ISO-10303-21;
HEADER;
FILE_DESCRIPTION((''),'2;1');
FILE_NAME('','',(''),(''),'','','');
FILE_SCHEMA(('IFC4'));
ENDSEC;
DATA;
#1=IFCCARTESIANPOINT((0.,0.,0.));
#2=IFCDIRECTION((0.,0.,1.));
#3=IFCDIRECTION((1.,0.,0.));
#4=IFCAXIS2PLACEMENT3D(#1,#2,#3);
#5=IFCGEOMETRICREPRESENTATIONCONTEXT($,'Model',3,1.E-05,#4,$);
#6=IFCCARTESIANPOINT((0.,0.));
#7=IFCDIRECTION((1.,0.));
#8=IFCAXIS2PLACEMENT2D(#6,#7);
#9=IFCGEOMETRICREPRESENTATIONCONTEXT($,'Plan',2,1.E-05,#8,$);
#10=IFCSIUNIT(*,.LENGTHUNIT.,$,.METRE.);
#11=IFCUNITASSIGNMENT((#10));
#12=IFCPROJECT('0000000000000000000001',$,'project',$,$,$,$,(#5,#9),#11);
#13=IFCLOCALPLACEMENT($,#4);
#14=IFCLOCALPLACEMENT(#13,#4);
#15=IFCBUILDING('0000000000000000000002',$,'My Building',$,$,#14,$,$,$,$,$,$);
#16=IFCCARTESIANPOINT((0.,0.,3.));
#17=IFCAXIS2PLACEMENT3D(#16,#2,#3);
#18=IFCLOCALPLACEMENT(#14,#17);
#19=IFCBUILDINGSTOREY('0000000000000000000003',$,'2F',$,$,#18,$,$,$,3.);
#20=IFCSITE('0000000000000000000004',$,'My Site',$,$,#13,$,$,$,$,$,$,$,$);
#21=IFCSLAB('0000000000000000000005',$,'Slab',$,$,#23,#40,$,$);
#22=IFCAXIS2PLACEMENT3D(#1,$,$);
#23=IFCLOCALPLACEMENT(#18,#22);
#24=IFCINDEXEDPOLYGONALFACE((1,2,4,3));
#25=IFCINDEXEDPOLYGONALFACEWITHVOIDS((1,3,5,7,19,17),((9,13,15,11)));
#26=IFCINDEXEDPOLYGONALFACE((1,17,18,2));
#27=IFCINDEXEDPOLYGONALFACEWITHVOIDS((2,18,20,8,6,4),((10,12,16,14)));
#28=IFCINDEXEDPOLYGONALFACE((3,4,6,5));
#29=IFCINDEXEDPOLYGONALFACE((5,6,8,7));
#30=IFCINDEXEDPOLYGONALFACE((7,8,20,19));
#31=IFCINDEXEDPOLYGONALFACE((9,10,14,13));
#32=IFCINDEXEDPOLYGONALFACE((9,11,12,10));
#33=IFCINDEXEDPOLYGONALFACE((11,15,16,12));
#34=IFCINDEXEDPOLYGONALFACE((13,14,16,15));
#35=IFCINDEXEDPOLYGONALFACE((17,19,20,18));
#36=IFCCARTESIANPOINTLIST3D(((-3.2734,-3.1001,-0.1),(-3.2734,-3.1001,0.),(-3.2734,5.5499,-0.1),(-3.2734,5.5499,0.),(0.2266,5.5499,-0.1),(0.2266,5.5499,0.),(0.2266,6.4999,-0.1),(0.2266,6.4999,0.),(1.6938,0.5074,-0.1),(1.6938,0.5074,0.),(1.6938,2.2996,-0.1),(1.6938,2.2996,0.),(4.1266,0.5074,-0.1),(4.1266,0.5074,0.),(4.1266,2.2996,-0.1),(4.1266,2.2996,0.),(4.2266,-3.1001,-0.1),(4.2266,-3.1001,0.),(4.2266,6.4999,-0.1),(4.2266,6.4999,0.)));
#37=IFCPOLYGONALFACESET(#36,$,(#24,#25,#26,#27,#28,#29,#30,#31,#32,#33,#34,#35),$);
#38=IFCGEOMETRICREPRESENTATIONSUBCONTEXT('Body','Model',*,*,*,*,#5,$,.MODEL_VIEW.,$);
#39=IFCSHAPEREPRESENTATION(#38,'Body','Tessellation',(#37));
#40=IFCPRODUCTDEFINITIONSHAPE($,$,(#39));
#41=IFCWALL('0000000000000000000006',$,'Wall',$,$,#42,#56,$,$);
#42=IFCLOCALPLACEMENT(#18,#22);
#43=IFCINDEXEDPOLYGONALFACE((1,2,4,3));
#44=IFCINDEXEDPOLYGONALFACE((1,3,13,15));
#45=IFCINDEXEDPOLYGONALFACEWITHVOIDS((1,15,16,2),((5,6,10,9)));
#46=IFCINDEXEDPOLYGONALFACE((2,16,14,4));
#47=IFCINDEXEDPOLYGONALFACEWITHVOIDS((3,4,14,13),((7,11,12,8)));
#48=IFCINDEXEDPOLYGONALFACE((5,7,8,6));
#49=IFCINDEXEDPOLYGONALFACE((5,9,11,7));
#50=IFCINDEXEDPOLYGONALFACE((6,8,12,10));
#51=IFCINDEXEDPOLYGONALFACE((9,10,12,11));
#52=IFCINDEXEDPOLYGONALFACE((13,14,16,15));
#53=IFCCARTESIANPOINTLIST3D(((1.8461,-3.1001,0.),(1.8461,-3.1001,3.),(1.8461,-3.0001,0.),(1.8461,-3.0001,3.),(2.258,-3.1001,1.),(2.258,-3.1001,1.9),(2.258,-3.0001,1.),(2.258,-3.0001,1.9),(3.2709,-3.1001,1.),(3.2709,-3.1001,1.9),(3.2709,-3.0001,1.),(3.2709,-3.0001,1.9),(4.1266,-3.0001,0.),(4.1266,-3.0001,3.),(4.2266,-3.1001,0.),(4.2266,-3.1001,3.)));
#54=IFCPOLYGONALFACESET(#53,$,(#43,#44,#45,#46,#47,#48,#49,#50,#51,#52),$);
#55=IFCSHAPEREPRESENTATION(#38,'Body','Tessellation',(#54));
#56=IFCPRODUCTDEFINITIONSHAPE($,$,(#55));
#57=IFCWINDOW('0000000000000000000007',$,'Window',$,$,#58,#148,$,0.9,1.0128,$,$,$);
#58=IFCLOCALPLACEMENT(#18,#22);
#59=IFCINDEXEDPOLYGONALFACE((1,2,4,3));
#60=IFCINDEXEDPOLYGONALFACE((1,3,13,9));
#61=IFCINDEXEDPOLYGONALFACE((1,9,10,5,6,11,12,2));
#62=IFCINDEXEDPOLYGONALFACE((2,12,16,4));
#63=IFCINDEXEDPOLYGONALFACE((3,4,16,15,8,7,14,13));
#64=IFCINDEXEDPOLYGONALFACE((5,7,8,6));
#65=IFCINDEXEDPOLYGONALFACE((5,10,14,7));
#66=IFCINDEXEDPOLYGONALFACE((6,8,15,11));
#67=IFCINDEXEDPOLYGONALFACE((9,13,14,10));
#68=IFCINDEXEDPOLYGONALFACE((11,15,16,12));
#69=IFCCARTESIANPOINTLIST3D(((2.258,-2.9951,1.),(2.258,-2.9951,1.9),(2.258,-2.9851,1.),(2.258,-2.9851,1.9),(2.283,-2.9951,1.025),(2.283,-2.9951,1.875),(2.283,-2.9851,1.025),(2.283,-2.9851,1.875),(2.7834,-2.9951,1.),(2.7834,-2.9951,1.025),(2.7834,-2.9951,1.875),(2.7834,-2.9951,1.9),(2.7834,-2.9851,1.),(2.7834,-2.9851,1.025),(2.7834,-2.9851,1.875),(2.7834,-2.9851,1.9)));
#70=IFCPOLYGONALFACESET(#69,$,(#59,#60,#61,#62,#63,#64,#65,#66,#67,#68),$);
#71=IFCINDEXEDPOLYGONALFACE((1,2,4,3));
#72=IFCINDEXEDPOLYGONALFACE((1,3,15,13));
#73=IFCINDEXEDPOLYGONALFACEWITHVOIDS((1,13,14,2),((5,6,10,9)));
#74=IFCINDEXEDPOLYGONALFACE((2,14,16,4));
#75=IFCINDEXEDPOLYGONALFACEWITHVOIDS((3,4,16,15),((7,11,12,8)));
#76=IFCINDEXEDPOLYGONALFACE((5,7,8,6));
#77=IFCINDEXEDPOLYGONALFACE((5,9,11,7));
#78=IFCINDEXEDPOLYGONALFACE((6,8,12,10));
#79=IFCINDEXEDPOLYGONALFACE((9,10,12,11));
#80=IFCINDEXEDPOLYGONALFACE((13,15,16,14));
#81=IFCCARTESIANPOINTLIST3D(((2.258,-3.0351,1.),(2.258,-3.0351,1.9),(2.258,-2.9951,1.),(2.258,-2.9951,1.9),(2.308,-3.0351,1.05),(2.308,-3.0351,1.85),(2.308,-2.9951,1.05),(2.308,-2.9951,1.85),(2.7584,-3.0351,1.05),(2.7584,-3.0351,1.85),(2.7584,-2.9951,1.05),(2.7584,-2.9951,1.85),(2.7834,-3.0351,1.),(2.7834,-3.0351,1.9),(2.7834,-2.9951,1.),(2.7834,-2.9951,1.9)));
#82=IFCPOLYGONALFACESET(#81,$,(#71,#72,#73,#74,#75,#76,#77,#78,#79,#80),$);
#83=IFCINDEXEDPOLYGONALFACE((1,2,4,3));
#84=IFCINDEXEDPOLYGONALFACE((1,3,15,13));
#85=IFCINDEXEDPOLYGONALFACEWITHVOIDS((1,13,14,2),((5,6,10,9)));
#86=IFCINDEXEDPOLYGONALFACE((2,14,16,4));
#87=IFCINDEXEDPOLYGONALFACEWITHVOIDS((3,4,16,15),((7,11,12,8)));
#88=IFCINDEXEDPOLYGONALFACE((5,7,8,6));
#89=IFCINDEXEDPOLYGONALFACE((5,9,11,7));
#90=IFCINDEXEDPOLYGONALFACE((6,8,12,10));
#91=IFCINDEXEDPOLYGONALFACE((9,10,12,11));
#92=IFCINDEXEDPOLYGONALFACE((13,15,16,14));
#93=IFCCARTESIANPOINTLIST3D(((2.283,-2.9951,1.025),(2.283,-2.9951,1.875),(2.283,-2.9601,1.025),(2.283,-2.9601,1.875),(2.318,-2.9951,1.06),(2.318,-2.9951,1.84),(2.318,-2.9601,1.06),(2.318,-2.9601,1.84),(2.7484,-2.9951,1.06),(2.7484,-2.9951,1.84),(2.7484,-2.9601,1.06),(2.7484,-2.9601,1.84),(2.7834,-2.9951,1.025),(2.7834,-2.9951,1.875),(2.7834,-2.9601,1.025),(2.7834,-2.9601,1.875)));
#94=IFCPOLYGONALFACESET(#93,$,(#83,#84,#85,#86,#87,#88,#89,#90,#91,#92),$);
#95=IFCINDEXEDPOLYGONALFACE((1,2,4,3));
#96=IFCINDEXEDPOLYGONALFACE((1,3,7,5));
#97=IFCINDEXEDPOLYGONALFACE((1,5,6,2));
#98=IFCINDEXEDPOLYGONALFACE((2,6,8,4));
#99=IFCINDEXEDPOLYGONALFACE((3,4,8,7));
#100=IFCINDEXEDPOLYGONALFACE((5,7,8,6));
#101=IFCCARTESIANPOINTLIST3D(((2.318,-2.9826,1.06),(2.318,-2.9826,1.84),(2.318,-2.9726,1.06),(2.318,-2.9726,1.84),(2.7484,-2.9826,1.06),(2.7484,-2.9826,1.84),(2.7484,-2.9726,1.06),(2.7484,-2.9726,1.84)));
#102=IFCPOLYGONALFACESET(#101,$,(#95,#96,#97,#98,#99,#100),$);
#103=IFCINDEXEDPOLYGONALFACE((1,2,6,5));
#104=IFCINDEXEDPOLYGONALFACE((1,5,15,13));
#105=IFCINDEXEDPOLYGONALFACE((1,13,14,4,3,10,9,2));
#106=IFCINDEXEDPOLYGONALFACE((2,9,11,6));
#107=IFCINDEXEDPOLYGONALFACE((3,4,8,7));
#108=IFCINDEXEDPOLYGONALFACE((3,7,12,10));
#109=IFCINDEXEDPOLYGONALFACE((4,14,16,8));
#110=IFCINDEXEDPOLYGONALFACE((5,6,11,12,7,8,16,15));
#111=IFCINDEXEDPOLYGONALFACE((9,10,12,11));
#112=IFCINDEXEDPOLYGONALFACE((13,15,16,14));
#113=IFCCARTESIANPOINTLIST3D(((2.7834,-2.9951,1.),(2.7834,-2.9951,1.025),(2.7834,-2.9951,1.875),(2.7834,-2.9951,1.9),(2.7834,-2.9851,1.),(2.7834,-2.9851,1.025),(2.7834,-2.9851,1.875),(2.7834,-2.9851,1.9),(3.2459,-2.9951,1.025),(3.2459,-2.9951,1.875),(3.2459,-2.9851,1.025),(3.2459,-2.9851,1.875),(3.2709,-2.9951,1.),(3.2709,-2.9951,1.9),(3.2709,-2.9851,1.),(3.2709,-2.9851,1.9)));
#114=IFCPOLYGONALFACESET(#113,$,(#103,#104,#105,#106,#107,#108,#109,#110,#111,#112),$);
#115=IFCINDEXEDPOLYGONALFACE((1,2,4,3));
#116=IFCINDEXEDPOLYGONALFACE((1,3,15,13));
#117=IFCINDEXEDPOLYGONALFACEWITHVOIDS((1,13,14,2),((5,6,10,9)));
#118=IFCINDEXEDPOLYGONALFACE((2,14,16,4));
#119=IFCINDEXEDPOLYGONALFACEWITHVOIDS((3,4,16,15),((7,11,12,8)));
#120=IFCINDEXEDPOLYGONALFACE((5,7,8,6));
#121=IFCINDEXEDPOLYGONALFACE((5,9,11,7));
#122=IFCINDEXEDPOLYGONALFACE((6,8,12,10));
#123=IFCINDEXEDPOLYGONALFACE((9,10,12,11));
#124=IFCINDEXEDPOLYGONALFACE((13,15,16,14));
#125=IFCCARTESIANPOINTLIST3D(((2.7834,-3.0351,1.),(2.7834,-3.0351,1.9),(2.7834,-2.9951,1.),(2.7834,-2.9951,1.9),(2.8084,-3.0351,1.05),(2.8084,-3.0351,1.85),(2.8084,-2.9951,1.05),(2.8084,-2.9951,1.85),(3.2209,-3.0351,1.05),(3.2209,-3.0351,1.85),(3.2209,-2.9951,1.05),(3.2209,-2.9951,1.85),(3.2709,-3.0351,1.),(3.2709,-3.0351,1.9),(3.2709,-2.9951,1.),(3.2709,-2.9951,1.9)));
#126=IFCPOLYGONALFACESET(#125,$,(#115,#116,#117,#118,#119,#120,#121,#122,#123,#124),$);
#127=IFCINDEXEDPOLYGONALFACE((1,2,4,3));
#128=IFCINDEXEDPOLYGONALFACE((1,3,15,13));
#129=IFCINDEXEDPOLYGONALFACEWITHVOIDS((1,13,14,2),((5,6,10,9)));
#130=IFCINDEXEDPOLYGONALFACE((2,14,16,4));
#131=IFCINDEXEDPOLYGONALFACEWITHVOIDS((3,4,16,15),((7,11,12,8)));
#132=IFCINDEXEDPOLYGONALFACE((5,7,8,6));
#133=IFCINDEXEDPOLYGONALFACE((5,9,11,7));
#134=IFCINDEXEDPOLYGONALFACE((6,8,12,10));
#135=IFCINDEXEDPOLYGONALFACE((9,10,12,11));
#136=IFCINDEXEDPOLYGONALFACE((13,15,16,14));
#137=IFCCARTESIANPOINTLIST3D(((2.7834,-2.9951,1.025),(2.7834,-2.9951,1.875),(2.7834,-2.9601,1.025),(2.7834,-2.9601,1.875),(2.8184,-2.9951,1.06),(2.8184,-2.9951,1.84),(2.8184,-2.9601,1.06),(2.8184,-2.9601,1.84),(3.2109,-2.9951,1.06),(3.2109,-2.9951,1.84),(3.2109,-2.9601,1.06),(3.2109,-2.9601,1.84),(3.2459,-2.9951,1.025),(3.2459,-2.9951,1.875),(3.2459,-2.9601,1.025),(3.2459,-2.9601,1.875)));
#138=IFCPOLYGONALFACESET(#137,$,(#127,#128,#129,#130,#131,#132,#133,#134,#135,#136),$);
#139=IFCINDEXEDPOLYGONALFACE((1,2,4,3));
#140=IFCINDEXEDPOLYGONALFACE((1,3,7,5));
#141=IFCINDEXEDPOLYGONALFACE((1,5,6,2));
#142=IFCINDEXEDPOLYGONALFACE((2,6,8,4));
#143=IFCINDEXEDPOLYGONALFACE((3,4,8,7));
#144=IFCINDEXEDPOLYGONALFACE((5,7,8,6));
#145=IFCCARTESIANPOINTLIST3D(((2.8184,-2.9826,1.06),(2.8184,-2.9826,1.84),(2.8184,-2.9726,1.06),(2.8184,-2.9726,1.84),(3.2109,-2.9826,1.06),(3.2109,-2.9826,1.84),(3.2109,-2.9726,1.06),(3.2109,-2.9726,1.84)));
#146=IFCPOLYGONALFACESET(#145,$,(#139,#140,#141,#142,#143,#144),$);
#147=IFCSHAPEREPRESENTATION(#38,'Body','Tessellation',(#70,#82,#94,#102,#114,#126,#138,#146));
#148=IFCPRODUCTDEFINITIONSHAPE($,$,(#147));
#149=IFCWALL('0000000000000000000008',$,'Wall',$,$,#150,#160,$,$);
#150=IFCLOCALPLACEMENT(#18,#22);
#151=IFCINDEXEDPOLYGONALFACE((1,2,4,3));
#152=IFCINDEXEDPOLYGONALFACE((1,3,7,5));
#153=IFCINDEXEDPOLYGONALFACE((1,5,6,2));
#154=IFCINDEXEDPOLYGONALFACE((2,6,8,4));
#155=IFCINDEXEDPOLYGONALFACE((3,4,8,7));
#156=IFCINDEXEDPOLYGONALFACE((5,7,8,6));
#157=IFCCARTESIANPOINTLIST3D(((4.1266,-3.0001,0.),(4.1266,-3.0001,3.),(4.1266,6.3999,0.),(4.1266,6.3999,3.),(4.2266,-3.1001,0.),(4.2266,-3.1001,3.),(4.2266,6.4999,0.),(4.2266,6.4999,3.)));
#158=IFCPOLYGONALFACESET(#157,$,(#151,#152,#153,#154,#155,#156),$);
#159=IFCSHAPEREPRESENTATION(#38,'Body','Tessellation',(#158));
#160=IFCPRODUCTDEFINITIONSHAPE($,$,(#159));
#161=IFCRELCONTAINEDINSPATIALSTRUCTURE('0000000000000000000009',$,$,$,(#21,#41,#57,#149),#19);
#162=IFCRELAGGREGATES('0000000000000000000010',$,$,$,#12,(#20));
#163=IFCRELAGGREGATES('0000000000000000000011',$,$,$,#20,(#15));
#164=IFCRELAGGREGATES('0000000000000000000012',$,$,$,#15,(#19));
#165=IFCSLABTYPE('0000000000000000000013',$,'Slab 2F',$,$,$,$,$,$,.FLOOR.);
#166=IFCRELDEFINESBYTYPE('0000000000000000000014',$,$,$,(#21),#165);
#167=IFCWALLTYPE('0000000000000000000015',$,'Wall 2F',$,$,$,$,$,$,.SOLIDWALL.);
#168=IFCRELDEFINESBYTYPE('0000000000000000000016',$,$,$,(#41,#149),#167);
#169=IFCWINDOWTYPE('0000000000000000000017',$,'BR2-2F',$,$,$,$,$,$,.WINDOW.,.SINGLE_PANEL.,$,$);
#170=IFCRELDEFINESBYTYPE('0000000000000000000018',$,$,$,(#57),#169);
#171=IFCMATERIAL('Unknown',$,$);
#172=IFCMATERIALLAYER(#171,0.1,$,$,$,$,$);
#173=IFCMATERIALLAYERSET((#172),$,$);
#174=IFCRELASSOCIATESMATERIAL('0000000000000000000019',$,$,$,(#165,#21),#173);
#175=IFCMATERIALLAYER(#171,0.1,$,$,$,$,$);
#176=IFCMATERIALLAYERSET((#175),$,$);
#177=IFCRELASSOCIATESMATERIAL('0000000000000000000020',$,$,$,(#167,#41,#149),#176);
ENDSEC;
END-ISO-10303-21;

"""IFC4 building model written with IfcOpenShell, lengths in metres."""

from ifc_helpers import new_model, entity, si_unit, frame, origin_with_axes, origin_2d_with_axis, place, context, subcontext, project, spatial, polyline, line, indexed_curve, outline, extrude, shape, source, transform, mapped, material, layer, layer_set, layer_usage, type_object, type_shapes, element, fill, save


model = new_model("IFC4")

# Units and contexts
model_context = context("Model", 3, precision=1e-05, world=origin_with_axes())
plan_context = context("Plan", 2, precision=1e-05, world=origin_2d_with_axis())
body_context_1 = subcontext(model_context, "Body", "Model", "MODEL_VIEW")
body_context_2 = subcontext(plan_context, "Body", "Plan", "PLAN_VIEW")
ifc_project = project(units=[si_unit("LENGTHUNIT", "METRE")], contexts=[model_context, plan_context])

# Site, building, storey
site_placement = place(None, origin_with_axes())
site = spatial("IfcSite", under=ifc_project, at=site_placement, Name="My Site")
building_placement = place(site_placement, origin_with_axes())
building = spatial("IfcBuilding", under=site, at=building_placement, Name="My Building")
storey_placement = place(building_placement, frame((0.0, 0.0, 3.0), z_axis=(0.0, 0.0, 1.0), x_axis=(1.0, 0.0, 0.0)))
storey = spatial("IfcBuildingStorey", under=building, at=storey_placement, Name="2F", Elevation=3.0)

# Slab, opening
ifc_material = material(Name="Unknown")
ifc_layer_1 = layer(ifc_material, 0.1)
ifc_layer_set_1 = layer_set([ifc_layer_1])
ifc_layer_usage_1 = layer_usage(ifc_layer_set_1, "AXIS3", "POSITIVE", -0.1)
slab_type = type_object("IfcSlabType", Name="Slab 2F", PredefinedType="FLOOR", material=ifc_layer_set_1)
slab_placement = place(storey_placement, frame((4.2266, -3.1001, 0.0), z_axis=(0.0, 0.0, 1.0), x_axis=(1.0, 0.0, 0.0)))
slab = element("IfcSlab", 1, at=slab_placement, inside=storey, type_object=slab_type, material=ifc_layer_usage_1, Name="Slab", context=body_context_1, shape_type="SweptSolid", body=[
    extrude(outline(indexed_curve([(0.0, 0.0), (-7.5, 0.0), (-7.5, 8.65), (-4.0, 8.65), (-4.0, 9.6), (0.0, 9.6), (0.0, 0.0)])), frame((0.0, 0.0, -0.1), z_axis=(0.0, 0.0, 1.0), x_axis=(1.0, 0.0, 0.0)), (0.0, 0.0, 1.0), 0.1),
])
opening_1_placement = place(slab_placement, origin_with_axes())
element("IfcOpeningElement", 2, at=opening_1_placement, cuts=slab, PredefinedType="OPENING", context=body_context_1, shape_type="SweptSolid", body=[
    extrude(outline(polyline([(-2.5329, 3.6075), (-0.1, 3.6075), (-0.1, 5.3997), (-2.5329, 5.3997), (-2.5329, 3.6075)])), frame((0.0, 0.0, -0.3), z_axis=(0.0, 0.0, 1.0), x_axis=(1.0, 0.0, 0.0)), (0.0, 0.0, 1.0), 0.6),
])

# Wall, opening, window
ifc_layer_2 = layer(ifc_material, 0.1)
ifc_layer_set_2 = layer_set([ifc_layer_2])
ifc_layer_usage_2 = layer_usage(ifc_layer_set_2, "AXIS2", "POSITIVE", 0.0)
wall_type = type_object("IfcWallType", Name="Wall 2F", PredefinedType="SOLIDWALL", material=ifc_layer_set_2)
wall_1_placement = place(storey_placement, frame((1.8461, -3.1001, 0.0), z_axis=(0.0, 0.0, 1.0), x_axis=(1.0, 0.0, 0.0)))
wall_1 = element("IfcWall", 3, at=wall_1_placement, inside=storey, type_object=wall_type, material=ifc_layer_usage_2, Name="Wall", context=body_context_1, shape_type="SweptSolid", body=[
    extrude(outline(polyline([(0.0, 0.0), (2.3805, 0.0), (2.2805, 0.1), (0.0, 0.1), (0.0, 0.0)])), origin_with_axes(), (0.0, 0.0, 1.0), 3.0),
])
opening_2_placement = place(wall_1_placement, frame((0.4119, 0.015, 1.0), z_axis=(0.0, 0.0, 1.0), x_axis=(1.0, 0.0, 0.0)))
opening_2 = element("IfcOpeningElement", 4, at=opening_2_placement, cuts=wall_1, PredefinedType="OPENING", context=body_context_1, shape_type="SweptSolid", body=[
    extrude(outline(polyline([(0.0, 0.0), (1.0128, 0.0), (1.0128, 0.9), (0.0, 0.9), (0.0, 0.0)])), frame((0.0, -0.6, 0.0), z_axis=(0.0, -1.0, 0.0), x_axis=(1.0, 0.0, 0.0)), (0.0, 0.0, -1.0), 1.2),
])
window_type_1 = type_object("IfcWindowType", Name="BR2-2F", PartitioningType="SINGLE_PANEL", PredefinedType="WINDOW")
shared_shape_1 = source(origin_with_axes(), body_context_1, "Body", "SweptSolid", [
    extrude(outline(indexed_curve([(0.5254, 0.0), (0.0, 0.0), (0.0, 0.9), (0.5254, 0.9), (0.5254, 0.875), (0.025, 0.875), (0.025, 0.025), (0.5254, 0.025)], segments=[line(1, 2, 3, 4, 5, 6, 7, 8, 1)])), frame((0.0, 0.09, 0.0), z_axis=(0.0, -1.0, 0.0), x_axis=(1.0, 0.0, 0.0)), (0.0, 0.0, -1.0), 0.01),
    extrude(outline(indexed_curve([(0.0, 0.0), (0.5254, 0.0), (0.5254, 0.9), (0.0, 0.9)], segments=[line(1, 2, 3, 4, 1)]), holes=[indexed_curve([(0.05, 0.05), (0.5004, 0.05), (0.5004, 0.85), (0.05, 0.85)], segments=[line(1, 2, 3, 4, 1)])]), frame((0.0, 0.05, 0.0), z_axis=(0.0, -1.0, 0.0), x_axis=(1.0, 0.0, 0.0)), (0.0, 0.0, -1.0), 0.04),
    extrude(outline(indexed_curve([(0.0, 0.0), (0.5004, 0.0), (0.5004, 0.85), (0.0, 0.85)], segments=[line(1, 2, 3, 4, 1)]), holes=[indexed_curve([(0.035, 0.035), (0.4654, 0.035), (0.4654, 0.815), (0.035, 0.815)], segments=[line(1, 2, 3, 4, 1)])]), frame((0.025, 0.09, 0.025), z_axis=(0.0, -1.0, 0.0), x_axis=(1.0, 0.0, 0.0)), (0.0, 0.0, -1.0), 0.035),
    extrude(outline(indexed_curve([(0.035, 0.035), (0.4654, 0.035), (0.4654, 0.815), (0.035, 0.815)], segments=[line(1, 2, 3, 4, 1)])), frame((0.025, 0.1025, 0.025), z_axis=(0.0, -1.0, 0.0), x_axis=(1.0, 0.0, 0.0)), (0.0, 0.0, -1.0), 0.01),
    extrude(outline(indexed_curve([(0.0, 0.9), (0.4875, 0.9), (0.4875, 0.0), (0.0, 0.0), (0.0, 0.025), (0.4625, 0.025), (0.4625, 0.875), (0.0, 0.875)], segments=[line(1, 2, 3, 4, 5, 6, 7, 8, 1)])), frame((0.5254, 0.09, 0.0), z_axis=(0.0, -1.0, 0.0), x_axis=(1.0, 0.0, 0.0)), (0.0, 0.0, -1.0), 0.01),
    extrude(outline(indexed_curve([(0.0, 0.0), (0.4875, 0.0), (0.4875, 0.9), (0.0, 0.9)], segments=[line(1, 2, 3, 4, 1)]), holes=[indexed_curve([(0.025, 0.05), (0.4375, 0.05), (0.4375, 0.85), (0.025, 0.85)], segments=[line(1, 2, 3, 4, 1)])]), frame((0.5254, 0.05, 0.0), z_axis=(0.0, -1.0, 0.0), x_axis=(1.0, 0.0, 0.0)), (0.0, 0.0, -1.0), 0.04),
    extrude(outline(indexed_curve([(0.0, 0.0), (0.4625, 0.0), (0.4625, 0.85), (0.0, 0.85)], segments=[line(1, 2, 3, 4, 1)]), holes=[indexed_curve([(0.035, 0.035), (0.4275, 0.035), (0.4275, 0.815), (0.035, 0.815)], segments=[line(1, 2, 3, 4, 1)])]), frame((0.5254, 0.09, 0.025), z_axis=(0.0, -1.0, 0.0), x_axis=(1.0, 0.0, 0.0)), (0.0, 0.0, -1.0), 0.035),
    extrude(outline(indexed_curve([(0.035, 0.035), (0.4275, 0.035), (0.4275, 0.815), (0.035, 0.815)], segments=[line(1, 2, 3, 4, 1)])), frame((0.5254, 0.1025, 0.025), z_axis=(0.0, -1.0, 0.0), x_axis=(1.0, 0.0, 0.0)), (0.0, 0.0, -1.0), 0.01),
])
shared_shape_2 = source(origin_with_axes(), body_context_2, "Body", "Curve2D", [
    entity("IfcIndexedPolyCurve", entity("IfcCartesianPointList2D", [[0.05, 0.05], [0.5004, 0.05]])),
    entity("IfcIndexedPolyCurve", entity("IfcCartesianPointList2D", [[0.0, 0.1], [0.025, 0.1], [0.025, 0.09], [0.05, 0.09], [0.05, 0.05], [0.0, 0.05]]), [entity("IfcLineIndex", [1, 2, 3, 4, 5, 6, 1])]),
    entity("IfcIndexedPolyCurve", entity("IfcCartesianPointList2D", [[0.5254, 0.1], [0.5254, 0.1], [0.5254, 0.09], [0.5004, 0.09], [0.5004, 0.05], [0.5254, 0.05]])),
    entity("IfcIndexedPolyCurve", entity("IfcCartesianPointList2D", [[0.025, 0.09], [0.06, 0.09], [0.06, 0.125], [0.025, 0.125]]), [entity("IfcLineIndex", [1, 2, 3, 4, 1])]),
    entity("IfcIndexedPolyCurve", entity("IfcCartesianPointList2D", [[0.5254, 0.09], [0.4904, 0.09], [0.4904, 0.125], [0.5254, 0.125]]), [entity("IfcLineIndex", [1, 2, 3, 4, 1])]),
    entity("IfcIndexedPolyCurve", entity("IfcCartesianPointList2D", [[0.06, 0.09], [0.4904, 0.09]])),
    entity("IfcIndexedPolyCurve", entity("IfcCartesianPointList2D", [[0.06, 0.125], [0.4904, 0.125]])),
    entity("IfcIndexedPolyCurve", entity("IfcCartesianPointList2D", [[0.06, 0.1075], [0.4904, 0.1075]])),
    entity("IfcIndexedPolyCurve", entity("IfcCartesianPointList2D", [[0.5504, 0.05], [0.9628, 0.05]])),
    entity("IfcIndexedPolyCurve", entity("IfcCartesianPointList2D", [[0.5254, 0.1], [0.5254, 0.1], [0.5254, 0.09], [0.5504, 0.09], [0.5504, 0.05], [0.5254, 0.05]])),
    entity("IfcIndexedPolyCurve", entity("IfcCartesianPointList2D", [[1.0128, 0.1], [0.9878, 0.1], [0.9878, 0.09], [0.9628, 0.09], [0.9628, 0.05], [1.0128, 0.05]]), [entity("IfcLineIndex", [1, 2, 3, 4, 5, 6, 1])]),
    entity("IfcIndexedPolyCurve", entity("IfcCartesianPointList2D", [[0.5254, 0.09], [0.5604, 0.09], [0.5604, 0.125], [0.5254, 0.125]]), [entity("IfcLineIndex", [1, 2, 3, 4, 1])]),
    entity("IfcIndexedPolyCurve", entity("IfcCartesianPointList2D", [[0.9878, 0.09], [0.9528, 0.09], [0.9528, 0.125], [0.9878, 0.125]]), [entity("IfcLineIndex", [1, 2, 3, 4, 1])]),
    entity("IfcIndexedPolyCurve", entity("IfcCartesianPointList2D", [[0.5604, 0.09], [0.9528, 0.09]])),
    entity("IfcIndexedPolyCurve", entity("IfcCartesianPointList2D", [[0.5604, 0.125], [0.9528, 0.125]])),
    entity("IfcIndexedPolyCurve", entity("IfcCartesianPointList2D", [[0.5604, 0.1075], [0.9528, 0.1075]])),
])
type_shapes(window_type_1, [shared_shape_1, shared_shape_2])
window_1_placement = place(storey_placement, frame((2.258, -3.0851, 1.0), z_axis=(0.0, 0.0, 1.0), x_axis=(1.0, 0.0, 0.0)))
window_1 = element("IfcWindow", 5, at=window_1_placement, inside=storey, type_object=window_type_1, Name="Window", OverallHeight=0.9, OverallWidth=1.0128, shapes=[
    shape(body_context_1, "Body", "MappedRepresentation", [mapped(shared_shape_1, transform((0.0, 0.0, 0.0), x_axis=(1.0, 0.0, 0.0), y_axis=(0.0, 1.0, 0.0), z_axis=(0.0, 0.0, 1.0), scale=1.0))]),
    shape(body_context_2, "Body", "MappedRepresentation", [mapped(shared_shape_2, transform((0.0, 0.0, 0.0), x_axis=(1.0, 0.0, 0.0), y_axis=(0.0, 1.0, 0.0), z_axis=(0.0, 0.0, 1.0), scale=1.0))]),
])
fill(opening_2, window_1)

# Wall
ifc_layer_usage_3 = layer_usage(ifc_layer_set_2, "AXIS2", "POSITIVE", 0.0)
wall_2_placement = place(storey_placement, frame((4.2266, -3.1001, 0.0), z_axis=(0.0, 0.0, 1.0), x_axis=(0.0, 1.0, 0.0)))
element("IfcWall", 6, at=wall_2_placement, inside=storey, type_object=wall_type, material=ifc_layer_usage_3, Name="Wall", context=body_context_1, shape_type="SweptSolid", body=[
    extrude(outline(polyline([(0.0, 0.0), (9.6, 0.0), (9.5, 0.1), (0.1, 0.1), (0.0, 0.0)])), origin_with_axes(), (0.0, 0.0, 1.0), 3.0),
])

save(model, "model.ifc")
